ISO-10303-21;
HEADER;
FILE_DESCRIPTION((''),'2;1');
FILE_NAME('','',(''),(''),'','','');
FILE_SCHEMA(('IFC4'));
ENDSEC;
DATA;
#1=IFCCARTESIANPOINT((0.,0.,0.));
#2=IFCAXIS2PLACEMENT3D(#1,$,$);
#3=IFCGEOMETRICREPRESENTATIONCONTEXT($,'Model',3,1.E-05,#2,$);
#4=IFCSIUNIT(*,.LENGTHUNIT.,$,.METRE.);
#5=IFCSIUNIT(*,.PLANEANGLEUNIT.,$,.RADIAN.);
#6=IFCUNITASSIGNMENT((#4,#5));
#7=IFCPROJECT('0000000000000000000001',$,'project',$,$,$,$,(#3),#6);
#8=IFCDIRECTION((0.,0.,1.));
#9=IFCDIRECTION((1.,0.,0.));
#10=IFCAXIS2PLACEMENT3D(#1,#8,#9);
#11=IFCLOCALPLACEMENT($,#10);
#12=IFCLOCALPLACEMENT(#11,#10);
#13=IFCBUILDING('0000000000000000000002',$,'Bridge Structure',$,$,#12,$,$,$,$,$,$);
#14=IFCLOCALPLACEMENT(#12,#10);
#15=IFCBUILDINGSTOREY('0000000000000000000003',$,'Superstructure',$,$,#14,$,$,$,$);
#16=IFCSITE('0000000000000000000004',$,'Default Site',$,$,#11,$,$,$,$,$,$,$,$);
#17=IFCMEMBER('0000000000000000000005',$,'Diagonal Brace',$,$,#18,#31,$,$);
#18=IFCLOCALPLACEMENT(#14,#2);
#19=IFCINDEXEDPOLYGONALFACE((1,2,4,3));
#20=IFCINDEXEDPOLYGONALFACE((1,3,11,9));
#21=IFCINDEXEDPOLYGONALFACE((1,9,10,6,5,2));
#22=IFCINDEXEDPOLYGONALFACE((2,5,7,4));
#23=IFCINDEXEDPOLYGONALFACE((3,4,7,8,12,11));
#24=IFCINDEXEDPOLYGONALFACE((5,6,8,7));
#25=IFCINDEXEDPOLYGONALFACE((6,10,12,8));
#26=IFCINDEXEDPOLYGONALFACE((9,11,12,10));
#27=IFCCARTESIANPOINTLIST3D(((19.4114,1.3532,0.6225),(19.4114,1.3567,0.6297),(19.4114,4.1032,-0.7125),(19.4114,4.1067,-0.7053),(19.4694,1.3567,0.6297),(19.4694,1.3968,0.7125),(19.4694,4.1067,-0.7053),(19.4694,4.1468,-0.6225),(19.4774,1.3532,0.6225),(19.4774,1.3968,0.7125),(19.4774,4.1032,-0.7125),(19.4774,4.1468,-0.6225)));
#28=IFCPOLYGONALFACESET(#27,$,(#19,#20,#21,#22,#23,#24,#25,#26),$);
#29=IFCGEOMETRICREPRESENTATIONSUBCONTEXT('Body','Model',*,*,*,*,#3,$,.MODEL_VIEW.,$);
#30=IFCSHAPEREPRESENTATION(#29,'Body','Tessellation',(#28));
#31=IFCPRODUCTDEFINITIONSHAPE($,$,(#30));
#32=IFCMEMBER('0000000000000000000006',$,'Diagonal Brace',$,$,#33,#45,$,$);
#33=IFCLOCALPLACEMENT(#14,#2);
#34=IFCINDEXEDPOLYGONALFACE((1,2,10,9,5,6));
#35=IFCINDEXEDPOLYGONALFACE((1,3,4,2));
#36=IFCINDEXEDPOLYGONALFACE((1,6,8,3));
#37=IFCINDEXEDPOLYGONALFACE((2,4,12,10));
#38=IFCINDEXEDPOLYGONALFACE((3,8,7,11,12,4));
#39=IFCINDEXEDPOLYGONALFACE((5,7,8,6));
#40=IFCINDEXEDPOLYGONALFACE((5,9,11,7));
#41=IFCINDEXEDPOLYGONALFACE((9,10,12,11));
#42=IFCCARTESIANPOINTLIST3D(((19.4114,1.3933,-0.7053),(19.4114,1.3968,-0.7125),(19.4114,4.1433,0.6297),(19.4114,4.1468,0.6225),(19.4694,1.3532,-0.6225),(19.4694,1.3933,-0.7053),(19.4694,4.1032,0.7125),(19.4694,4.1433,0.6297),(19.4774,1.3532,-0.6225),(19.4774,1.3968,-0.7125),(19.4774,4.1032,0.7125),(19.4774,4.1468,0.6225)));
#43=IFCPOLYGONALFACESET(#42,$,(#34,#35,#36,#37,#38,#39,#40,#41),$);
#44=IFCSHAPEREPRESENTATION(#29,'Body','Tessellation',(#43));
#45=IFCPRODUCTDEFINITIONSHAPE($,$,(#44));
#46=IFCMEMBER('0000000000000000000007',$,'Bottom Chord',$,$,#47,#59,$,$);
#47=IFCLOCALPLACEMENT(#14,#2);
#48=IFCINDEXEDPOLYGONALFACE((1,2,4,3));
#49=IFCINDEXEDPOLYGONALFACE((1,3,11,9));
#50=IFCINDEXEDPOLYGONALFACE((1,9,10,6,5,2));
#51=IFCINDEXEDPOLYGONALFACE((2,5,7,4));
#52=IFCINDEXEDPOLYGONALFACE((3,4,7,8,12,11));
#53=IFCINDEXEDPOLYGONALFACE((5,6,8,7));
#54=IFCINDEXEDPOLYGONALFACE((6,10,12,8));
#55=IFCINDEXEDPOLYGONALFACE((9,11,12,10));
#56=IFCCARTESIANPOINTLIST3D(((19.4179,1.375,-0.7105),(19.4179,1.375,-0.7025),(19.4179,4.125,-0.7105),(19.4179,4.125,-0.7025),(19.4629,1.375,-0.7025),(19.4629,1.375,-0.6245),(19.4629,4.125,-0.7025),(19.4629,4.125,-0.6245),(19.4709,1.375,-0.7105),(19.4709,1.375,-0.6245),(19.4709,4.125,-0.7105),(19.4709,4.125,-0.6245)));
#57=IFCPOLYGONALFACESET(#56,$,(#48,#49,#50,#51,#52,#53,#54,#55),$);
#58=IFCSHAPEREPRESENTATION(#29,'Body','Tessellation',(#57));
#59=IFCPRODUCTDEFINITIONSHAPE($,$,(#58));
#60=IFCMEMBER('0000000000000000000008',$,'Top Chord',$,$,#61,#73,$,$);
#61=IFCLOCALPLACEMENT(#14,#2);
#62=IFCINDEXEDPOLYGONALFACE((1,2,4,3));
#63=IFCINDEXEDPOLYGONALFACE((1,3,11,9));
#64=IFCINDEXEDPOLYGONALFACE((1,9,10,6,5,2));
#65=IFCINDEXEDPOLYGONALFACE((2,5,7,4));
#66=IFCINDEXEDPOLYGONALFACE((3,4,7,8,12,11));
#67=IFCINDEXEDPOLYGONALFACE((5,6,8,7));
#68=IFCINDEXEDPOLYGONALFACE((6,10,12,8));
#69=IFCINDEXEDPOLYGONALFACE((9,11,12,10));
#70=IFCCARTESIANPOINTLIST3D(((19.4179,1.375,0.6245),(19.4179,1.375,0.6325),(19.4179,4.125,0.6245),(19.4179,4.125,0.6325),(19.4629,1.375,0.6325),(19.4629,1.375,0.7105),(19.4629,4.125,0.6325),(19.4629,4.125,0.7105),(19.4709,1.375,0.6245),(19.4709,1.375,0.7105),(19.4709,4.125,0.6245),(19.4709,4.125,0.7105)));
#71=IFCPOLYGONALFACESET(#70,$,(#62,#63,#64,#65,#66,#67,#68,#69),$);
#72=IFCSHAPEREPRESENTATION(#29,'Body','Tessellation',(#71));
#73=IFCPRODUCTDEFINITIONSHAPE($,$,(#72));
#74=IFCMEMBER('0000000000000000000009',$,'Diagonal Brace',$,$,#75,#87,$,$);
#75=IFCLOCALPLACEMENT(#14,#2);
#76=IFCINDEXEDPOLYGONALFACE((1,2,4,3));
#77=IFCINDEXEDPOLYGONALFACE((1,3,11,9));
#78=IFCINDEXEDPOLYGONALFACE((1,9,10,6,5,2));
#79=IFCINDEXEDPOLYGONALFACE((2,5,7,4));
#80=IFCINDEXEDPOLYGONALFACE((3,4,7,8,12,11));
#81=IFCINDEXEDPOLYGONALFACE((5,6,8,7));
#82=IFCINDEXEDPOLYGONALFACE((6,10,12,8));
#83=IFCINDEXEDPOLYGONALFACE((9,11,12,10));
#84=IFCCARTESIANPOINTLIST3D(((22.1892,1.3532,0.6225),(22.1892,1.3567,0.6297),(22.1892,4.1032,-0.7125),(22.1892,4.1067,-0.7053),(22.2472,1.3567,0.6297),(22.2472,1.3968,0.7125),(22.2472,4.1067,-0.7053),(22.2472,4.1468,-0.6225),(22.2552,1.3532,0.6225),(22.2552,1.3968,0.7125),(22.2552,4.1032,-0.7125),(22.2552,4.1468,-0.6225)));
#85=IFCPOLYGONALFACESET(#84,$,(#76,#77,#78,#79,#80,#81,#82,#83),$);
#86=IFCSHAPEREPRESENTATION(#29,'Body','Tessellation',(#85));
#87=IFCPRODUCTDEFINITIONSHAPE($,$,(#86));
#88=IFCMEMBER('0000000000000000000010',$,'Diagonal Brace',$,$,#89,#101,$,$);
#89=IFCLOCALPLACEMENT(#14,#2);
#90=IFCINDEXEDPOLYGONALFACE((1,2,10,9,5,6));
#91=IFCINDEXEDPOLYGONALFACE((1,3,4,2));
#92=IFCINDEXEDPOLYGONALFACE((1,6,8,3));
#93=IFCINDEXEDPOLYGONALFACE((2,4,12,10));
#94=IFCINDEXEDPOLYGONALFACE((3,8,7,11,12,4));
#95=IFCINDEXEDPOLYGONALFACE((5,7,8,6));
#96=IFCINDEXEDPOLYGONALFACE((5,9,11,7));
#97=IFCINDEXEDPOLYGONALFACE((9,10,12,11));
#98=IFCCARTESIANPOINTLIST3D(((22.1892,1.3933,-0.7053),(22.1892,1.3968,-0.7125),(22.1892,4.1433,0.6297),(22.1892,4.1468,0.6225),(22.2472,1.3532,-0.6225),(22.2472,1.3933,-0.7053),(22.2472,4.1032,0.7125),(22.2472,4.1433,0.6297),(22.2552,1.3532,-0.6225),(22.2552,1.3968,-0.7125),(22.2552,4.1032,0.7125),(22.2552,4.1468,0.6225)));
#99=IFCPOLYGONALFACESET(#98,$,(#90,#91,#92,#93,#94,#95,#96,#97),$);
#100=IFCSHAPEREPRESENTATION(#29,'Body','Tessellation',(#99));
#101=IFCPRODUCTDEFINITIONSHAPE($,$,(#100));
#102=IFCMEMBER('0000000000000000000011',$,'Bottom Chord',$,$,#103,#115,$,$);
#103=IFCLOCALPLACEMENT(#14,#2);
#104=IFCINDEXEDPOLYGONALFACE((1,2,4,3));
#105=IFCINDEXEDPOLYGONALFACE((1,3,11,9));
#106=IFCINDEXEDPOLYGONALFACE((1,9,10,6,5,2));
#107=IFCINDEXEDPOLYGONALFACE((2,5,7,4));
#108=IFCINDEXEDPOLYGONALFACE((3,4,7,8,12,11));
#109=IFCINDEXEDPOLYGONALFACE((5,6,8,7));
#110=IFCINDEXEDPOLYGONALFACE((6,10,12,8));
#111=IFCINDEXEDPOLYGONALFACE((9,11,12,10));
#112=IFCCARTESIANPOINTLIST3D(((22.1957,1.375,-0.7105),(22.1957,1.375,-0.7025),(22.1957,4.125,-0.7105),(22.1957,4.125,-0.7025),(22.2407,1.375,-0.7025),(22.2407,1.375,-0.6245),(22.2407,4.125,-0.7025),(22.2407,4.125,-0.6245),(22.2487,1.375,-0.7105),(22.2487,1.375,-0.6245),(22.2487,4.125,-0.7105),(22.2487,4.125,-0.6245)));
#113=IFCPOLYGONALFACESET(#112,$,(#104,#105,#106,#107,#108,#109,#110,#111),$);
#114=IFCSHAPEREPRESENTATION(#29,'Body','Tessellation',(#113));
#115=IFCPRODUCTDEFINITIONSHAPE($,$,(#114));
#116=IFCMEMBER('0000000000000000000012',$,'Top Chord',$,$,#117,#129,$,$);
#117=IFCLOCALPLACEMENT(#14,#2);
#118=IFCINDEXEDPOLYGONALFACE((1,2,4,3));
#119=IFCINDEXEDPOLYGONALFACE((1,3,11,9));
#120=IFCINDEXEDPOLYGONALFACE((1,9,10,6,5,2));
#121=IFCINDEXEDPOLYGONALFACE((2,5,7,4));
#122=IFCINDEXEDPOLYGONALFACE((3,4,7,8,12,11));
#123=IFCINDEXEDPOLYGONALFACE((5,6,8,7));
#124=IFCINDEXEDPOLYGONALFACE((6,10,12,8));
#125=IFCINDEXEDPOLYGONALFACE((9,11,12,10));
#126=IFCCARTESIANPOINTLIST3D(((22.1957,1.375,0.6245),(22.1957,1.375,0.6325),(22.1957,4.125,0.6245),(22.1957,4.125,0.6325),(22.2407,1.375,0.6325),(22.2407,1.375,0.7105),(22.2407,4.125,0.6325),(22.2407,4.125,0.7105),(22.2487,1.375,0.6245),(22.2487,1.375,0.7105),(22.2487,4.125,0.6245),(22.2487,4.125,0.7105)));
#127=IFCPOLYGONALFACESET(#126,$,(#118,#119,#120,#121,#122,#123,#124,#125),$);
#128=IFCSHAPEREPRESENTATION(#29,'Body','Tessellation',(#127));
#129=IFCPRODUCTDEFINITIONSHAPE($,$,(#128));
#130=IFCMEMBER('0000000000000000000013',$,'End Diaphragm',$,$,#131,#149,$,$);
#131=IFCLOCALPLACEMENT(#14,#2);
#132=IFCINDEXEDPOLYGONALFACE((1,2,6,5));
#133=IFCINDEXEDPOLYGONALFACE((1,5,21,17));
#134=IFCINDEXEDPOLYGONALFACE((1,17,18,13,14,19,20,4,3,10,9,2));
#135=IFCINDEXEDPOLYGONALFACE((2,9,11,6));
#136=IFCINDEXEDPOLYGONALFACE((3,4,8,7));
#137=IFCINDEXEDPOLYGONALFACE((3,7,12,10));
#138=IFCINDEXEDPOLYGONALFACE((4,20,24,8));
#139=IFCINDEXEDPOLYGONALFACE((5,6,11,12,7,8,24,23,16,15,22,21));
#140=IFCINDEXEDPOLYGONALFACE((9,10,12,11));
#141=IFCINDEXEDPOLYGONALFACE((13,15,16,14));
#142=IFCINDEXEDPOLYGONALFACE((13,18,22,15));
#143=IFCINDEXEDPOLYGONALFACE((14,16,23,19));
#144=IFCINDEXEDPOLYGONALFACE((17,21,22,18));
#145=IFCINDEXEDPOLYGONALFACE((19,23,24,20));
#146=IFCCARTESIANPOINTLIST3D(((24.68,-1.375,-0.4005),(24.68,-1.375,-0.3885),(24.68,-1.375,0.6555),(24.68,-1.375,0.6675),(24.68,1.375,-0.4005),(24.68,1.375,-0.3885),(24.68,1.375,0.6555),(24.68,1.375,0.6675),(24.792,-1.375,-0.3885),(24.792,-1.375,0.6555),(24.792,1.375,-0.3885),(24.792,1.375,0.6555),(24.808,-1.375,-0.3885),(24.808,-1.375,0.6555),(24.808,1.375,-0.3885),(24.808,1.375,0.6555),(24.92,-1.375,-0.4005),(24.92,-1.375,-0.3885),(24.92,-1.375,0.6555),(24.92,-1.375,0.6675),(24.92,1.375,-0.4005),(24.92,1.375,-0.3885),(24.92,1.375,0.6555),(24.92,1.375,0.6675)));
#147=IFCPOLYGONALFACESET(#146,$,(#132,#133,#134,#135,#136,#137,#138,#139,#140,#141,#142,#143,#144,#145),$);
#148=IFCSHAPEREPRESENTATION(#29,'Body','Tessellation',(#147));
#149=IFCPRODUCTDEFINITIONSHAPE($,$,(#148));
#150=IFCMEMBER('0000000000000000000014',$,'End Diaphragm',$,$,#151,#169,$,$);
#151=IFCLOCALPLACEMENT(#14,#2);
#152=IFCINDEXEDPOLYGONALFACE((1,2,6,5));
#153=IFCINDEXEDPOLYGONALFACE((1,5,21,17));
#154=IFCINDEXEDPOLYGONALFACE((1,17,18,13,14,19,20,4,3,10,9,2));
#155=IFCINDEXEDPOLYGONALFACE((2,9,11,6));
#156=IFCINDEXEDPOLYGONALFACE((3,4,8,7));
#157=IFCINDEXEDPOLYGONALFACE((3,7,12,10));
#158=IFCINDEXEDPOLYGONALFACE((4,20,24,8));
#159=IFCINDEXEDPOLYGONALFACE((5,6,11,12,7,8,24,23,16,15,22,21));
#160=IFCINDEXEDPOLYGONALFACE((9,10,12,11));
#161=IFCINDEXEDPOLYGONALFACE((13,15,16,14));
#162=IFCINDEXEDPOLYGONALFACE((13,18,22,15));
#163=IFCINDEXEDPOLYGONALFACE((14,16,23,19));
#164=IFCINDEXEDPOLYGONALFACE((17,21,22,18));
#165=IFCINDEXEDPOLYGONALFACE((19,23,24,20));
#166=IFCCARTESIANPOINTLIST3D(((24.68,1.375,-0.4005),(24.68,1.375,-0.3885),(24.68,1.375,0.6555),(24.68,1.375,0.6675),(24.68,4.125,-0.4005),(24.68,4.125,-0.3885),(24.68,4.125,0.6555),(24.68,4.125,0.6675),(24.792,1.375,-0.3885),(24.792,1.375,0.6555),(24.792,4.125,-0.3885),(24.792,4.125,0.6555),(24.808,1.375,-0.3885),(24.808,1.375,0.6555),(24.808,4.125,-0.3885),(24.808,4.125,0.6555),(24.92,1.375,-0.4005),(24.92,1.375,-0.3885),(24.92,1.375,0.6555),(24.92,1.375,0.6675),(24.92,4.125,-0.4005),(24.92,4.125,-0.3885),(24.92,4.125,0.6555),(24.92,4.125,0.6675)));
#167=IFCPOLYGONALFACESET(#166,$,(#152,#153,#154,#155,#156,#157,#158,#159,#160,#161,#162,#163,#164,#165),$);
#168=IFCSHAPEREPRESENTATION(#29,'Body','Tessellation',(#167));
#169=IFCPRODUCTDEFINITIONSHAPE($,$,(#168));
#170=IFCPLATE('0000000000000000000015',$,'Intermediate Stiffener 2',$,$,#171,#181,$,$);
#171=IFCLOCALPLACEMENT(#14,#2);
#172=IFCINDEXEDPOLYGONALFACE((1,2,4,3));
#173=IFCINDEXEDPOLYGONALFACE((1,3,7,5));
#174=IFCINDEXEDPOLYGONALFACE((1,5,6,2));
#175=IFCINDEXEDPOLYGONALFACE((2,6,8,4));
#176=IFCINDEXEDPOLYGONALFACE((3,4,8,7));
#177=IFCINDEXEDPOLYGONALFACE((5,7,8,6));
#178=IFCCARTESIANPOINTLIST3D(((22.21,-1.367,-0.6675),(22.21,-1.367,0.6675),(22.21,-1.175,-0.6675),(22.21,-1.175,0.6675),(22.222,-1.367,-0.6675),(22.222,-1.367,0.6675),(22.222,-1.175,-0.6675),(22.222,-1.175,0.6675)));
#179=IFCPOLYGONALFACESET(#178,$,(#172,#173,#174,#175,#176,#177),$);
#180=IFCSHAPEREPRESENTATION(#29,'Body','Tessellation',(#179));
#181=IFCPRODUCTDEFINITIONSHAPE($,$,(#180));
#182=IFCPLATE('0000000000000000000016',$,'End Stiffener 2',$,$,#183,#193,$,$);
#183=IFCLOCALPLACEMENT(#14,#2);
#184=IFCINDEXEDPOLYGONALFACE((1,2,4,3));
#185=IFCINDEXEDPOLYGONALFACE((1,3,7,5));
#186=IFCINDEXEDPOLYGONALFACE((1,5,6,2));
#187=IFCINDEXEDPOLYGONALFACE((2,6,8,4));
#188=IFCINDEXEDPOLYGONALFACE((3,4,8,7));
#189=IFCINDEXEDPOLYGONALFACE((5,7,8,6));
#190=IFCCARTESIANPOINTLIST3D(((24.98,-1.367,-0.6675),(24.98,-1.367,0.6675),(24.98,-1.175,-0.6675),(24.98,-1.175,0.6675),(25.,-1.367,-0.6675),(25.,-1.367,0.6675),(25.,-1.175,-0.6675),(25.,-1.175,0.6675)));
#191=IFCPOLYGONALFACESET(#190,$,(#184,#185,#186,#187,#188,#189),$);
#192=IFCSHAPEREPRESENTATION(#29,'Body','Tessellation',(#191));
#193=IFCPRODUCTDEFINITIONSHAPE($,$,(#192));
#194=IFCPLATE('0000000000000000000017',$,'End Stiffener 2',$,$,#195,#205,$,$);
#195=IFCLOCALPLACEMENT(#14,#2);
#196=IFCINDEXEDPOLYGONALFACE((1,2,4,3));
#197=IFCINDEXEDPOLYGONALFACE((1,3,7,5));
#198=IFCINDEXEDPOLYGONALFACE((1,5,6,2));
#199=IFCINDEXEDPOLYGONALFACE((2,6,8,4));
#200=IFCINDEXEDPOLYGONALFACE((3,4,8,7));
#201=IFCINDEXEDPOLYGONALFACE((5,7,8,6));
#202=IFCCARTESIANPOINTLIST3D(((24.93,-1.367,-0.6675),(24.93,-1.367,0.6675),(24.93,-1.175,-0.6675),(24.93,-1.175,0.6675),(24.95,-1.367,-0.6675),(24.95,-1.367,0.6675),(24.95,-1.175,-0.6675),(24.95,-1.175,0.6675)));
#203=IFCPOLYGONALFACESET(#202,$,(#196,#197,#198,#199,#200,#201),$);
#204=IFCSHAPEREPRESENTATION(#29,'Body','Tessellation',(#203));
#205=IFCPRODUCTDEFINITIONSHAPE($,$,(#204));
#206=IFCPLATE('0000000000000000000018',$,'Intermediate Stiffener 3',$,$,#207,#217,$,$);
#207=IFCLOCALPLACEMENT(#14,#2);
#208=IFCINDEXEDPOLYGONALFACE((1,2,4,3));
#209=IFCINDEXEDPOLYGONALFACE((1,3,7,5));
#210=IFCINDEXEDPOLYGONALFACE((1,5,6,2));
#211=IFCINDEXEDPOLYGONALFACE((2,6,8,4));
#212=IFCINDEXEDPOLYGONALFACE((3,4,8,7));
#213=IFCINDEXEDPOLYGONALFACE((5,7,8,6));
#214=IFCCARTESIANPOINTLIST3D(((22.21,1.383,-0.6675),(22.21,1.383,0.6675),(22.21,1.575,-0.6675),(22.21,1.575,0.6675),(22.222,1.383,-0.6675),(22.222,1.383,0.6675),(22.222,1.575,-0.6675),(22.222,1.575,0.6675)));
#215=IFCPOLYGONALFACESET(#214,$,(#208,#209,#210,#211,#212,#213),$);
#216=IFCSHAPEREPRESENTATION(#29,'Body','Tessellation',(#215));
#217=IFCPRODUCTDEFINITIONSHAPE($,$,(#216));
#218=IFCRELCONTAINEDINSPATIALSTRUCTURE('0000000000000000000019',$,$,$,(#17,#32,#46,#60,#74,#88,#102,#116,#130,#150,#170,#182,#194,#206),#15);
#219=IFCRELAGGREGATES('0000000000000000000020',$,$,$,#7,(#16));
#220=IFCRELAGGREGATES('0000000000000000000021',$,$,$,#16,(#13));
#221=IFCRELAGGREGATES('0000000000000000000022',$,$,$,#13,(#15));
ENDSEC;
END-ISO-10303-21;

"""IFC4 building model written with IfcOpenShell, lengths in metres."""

from ifc_helpers import new_model, si_unit, frame, origin, origin_with_axes, origin_2d_with_axis, place, context, subcontext, project, spatial, rectangle, i_section, l_section, extrude, element, save


model = new_model("IFC4")

# Units and contexts
model_context = context("Model", 3, precision=1e-05, world=origin())
body_context = subcontext(model_context, "Body", "Model", "MODEL_VIEW")
ifc_project = project(units=[si_unit("LENGTHUNIT", "METRE"), si_unit("PLANEANGLEUNIT", "RADIAN")], contexts=[model_context])

# Site, building, storey
site_placement = place(None, origin_with_axes())
site = spatial("IfcSite", under=ifc_project, at=site_placement, Name="Default Site")
building_placement = place(site_placement, origin_with_axes())
building = spatial("IfcBuilding", under=site, at=building_placement, Name="Bridge Structure")
storey_placement = place(building_placement, origin_with_axes())
storey = spatial("IfcBuildingStorey", under=building, at=storey_placement, Name="Superstructure")

# Members
for number, where, z_axis, x_axis, name in (
    (1, (19.4444, 1.375, 0.6675), (0.0, 0.8996, -0.436715), (-1.0, 0.0, 0.0), "Diagonal Brace"),
    (2, (19.4444, 1.375, -0.6675), (0.0, 0.8996, 0.436715), (-1.0, 0.0, 0.0), "Diagonal Brace"),
):
    element("IfcMember", number, at=place(storey_placement, frame(where, z_axis=z_axis, x_axis=x_axis)), inside=storey, Name=name, context=body_context, shape_type="SweptSolid", body=[
        extrude(l_section(Depth=0.1, Width=0.066, Thickness=0.008, at=origin_2d_with_axis()), origin_with_axes(), (0.0, 0.0, 1.0), 3.0569),
    ])
for number, where, z_axis, x_axis, name in (
    (3, (19.4444, 1.375, -0.6675), (0.0, 1.0, 0.0), (-1.0, 0.0, 0.0), "Bottom Chord"),
    (4, (19.4444, 1.375, 0.6675), (0.0, 1.0, 0.0), (-1.0, 0.0, 0.0), "Top Chord"),
):
    element("IfcMember", number, at=place(storey_placement, frame(where, z_axis=z_axis, x_axis=x_axis)), inside=storey, Name=name, context=body_context, shape_type="SweptSolid", body=[
        extrude(l_section(Depth=0.086, Width=0.053, Thickness=0.008, at=origin_2d_with_axis()), origin_with_axes(), (0.0, 0.0, 1.0), 2.75),
    ])
for number, where, z_axis, x_axis, name in (
    (5, (22.2222, 1.375, 0.6675), (0.0, 0.8996, -0.436715), (-1.0, 0.0, 0.0), "Diagonal Brace"),
    (6, (22.2222, 1.375, -0.6675), (0.0, 0.8996, 0.436715), (-1.0, 0.0, 0.0), "Diagonal Brace"),
):
    element("IfcMember", number, at=place(storey_placement, frame(where, z_axis=z_axis, x_axis=x_axis)), inside=storey, Name=name, context=body_context, shape_type="SweptSolid", body=[
        extrude(l_section(Depth=0.1, Width=0.066, Thickness=0.008, at=origin_2d_with_axis()), origin_with_axes(), (0.0, 0.0, 1.0), 3.0569),
    ])
for number, where, z_axis, x_axis, name in (
    (7, (22.2222, 1.375, -0.6675), (0.0, 1.0, 0.0), (-1.0, 0.0, 0.0), "Bottom Chord"),
    (8, (22.2222, 1.375, 0.6675), (0.0, 1.0, 0.0), (-1.0, 0.0, 0.0), "Top Chord"),
):
    element("IfcMember", number, at=place(storey_placement, frame(where, z_axis=z_axis, x_axis=x_axis)), inside=storey, Name=name, context=body_context, shape_type="SweptSolid", body=[
        extrude(l_section(Depth=0.086, Width=0.053, Thickness=0.008, at=origin_2d_with_axis()), origin_with_axes(), (0.0, 0.0, 1.0), 2.75),
    ])
for number, where, z_axis, x_axis, name in (
    (9, (24.8, -1.375, 0.1335), (0.0, 1.0, 0.0), (-1.0, 0.0, 0.0), "End Diaphragm"),
    (10, (24.8, 1.375, 0.1335), (0.0, 1.0, 0.0), (-1.0, 0.0, 0.0), "End Diaphragm"),
):
    element("IfcMember", number, at=place(storey_placement, frame(where, z_axis=z_axis, x_axis=x_axis)), inside=storey, Name=name, context=body_context, shape_type="SweptSolid", body=[
        extrude(i_section(OverallWidth=0.24, OverallDepth=1.068, WebThickness=0.016, FlangeThickness=0.012, at=origin_2d_with_axis()), origin_with_axes(), (0.0, 0.0, 1.0), 2.75),
    ])

# Plates
plate_placement = place(storey_placement, frame((22.216, -1.271, -0.6675), z_axis=(0.0, 0.0, 1.0), x_axis=(1.0, 0.0, 0.0)))
element("IfcPlate", 11, at=plate_placement, inside=storey, Name="Intermediate Stiffener 2", context=body_context, shape_type="SweptSolid", body=[
    extrude(rectangle(XDim=0.012, YDim=0.192, at=origin_2d_with_axis()), origin_with_axes(), (0.0, 0.0, 1.0), 1.335),
])
for number, where, z_axis, x_axis, name in (
    (12, (24.99, -1.271, -0.6675), (0.0, 0.0, 1.0), (1.0, 0.0, 0.0), "End Stiffener 2"),
    (13, (24.94, -1.271, -0.6675), (0.0, 0.0, 1.0), (1.0, 0.0, 0.0), "End Stiffener 2"),
):
    element("IfcPlate", number, at=place(storey_placement, frame(where, z_axis=z_axis, x_axis=x_axis)), inside=storey, Name=name, context=body_context, shape_type="SweptSolid", body=[
        extrude(rectangle(XDim=0.02, YDim=0.192, at=origin_2d_with_axis()), origin_with_axes(), (0.0, 0.0, 1.0), 1.335),
    ])
for number, where, z_axis, x_axis, name in (
    (14, (22.216, 1.479, -0.6675), (0.0, 0.0, 1.0), (1.0, 0.0, 0.0), "Intermediate Stiffener 3"),
):
    element("IfcPlate", number, at=place(storey_placement, frame(where, z_axis=z_axis, x_axis=x_axis)), inside=storey, Name=name, context=body_context, shape_type="SweptSolid", body=[
        extrude(rectangle(XDim=0.012, YDim=0.192, at=origin_2d_with_axis()), origin_with_axes(), (0.0, 0.0, 1.0), 1.335),
    ])

save(model, "model.ifc")
